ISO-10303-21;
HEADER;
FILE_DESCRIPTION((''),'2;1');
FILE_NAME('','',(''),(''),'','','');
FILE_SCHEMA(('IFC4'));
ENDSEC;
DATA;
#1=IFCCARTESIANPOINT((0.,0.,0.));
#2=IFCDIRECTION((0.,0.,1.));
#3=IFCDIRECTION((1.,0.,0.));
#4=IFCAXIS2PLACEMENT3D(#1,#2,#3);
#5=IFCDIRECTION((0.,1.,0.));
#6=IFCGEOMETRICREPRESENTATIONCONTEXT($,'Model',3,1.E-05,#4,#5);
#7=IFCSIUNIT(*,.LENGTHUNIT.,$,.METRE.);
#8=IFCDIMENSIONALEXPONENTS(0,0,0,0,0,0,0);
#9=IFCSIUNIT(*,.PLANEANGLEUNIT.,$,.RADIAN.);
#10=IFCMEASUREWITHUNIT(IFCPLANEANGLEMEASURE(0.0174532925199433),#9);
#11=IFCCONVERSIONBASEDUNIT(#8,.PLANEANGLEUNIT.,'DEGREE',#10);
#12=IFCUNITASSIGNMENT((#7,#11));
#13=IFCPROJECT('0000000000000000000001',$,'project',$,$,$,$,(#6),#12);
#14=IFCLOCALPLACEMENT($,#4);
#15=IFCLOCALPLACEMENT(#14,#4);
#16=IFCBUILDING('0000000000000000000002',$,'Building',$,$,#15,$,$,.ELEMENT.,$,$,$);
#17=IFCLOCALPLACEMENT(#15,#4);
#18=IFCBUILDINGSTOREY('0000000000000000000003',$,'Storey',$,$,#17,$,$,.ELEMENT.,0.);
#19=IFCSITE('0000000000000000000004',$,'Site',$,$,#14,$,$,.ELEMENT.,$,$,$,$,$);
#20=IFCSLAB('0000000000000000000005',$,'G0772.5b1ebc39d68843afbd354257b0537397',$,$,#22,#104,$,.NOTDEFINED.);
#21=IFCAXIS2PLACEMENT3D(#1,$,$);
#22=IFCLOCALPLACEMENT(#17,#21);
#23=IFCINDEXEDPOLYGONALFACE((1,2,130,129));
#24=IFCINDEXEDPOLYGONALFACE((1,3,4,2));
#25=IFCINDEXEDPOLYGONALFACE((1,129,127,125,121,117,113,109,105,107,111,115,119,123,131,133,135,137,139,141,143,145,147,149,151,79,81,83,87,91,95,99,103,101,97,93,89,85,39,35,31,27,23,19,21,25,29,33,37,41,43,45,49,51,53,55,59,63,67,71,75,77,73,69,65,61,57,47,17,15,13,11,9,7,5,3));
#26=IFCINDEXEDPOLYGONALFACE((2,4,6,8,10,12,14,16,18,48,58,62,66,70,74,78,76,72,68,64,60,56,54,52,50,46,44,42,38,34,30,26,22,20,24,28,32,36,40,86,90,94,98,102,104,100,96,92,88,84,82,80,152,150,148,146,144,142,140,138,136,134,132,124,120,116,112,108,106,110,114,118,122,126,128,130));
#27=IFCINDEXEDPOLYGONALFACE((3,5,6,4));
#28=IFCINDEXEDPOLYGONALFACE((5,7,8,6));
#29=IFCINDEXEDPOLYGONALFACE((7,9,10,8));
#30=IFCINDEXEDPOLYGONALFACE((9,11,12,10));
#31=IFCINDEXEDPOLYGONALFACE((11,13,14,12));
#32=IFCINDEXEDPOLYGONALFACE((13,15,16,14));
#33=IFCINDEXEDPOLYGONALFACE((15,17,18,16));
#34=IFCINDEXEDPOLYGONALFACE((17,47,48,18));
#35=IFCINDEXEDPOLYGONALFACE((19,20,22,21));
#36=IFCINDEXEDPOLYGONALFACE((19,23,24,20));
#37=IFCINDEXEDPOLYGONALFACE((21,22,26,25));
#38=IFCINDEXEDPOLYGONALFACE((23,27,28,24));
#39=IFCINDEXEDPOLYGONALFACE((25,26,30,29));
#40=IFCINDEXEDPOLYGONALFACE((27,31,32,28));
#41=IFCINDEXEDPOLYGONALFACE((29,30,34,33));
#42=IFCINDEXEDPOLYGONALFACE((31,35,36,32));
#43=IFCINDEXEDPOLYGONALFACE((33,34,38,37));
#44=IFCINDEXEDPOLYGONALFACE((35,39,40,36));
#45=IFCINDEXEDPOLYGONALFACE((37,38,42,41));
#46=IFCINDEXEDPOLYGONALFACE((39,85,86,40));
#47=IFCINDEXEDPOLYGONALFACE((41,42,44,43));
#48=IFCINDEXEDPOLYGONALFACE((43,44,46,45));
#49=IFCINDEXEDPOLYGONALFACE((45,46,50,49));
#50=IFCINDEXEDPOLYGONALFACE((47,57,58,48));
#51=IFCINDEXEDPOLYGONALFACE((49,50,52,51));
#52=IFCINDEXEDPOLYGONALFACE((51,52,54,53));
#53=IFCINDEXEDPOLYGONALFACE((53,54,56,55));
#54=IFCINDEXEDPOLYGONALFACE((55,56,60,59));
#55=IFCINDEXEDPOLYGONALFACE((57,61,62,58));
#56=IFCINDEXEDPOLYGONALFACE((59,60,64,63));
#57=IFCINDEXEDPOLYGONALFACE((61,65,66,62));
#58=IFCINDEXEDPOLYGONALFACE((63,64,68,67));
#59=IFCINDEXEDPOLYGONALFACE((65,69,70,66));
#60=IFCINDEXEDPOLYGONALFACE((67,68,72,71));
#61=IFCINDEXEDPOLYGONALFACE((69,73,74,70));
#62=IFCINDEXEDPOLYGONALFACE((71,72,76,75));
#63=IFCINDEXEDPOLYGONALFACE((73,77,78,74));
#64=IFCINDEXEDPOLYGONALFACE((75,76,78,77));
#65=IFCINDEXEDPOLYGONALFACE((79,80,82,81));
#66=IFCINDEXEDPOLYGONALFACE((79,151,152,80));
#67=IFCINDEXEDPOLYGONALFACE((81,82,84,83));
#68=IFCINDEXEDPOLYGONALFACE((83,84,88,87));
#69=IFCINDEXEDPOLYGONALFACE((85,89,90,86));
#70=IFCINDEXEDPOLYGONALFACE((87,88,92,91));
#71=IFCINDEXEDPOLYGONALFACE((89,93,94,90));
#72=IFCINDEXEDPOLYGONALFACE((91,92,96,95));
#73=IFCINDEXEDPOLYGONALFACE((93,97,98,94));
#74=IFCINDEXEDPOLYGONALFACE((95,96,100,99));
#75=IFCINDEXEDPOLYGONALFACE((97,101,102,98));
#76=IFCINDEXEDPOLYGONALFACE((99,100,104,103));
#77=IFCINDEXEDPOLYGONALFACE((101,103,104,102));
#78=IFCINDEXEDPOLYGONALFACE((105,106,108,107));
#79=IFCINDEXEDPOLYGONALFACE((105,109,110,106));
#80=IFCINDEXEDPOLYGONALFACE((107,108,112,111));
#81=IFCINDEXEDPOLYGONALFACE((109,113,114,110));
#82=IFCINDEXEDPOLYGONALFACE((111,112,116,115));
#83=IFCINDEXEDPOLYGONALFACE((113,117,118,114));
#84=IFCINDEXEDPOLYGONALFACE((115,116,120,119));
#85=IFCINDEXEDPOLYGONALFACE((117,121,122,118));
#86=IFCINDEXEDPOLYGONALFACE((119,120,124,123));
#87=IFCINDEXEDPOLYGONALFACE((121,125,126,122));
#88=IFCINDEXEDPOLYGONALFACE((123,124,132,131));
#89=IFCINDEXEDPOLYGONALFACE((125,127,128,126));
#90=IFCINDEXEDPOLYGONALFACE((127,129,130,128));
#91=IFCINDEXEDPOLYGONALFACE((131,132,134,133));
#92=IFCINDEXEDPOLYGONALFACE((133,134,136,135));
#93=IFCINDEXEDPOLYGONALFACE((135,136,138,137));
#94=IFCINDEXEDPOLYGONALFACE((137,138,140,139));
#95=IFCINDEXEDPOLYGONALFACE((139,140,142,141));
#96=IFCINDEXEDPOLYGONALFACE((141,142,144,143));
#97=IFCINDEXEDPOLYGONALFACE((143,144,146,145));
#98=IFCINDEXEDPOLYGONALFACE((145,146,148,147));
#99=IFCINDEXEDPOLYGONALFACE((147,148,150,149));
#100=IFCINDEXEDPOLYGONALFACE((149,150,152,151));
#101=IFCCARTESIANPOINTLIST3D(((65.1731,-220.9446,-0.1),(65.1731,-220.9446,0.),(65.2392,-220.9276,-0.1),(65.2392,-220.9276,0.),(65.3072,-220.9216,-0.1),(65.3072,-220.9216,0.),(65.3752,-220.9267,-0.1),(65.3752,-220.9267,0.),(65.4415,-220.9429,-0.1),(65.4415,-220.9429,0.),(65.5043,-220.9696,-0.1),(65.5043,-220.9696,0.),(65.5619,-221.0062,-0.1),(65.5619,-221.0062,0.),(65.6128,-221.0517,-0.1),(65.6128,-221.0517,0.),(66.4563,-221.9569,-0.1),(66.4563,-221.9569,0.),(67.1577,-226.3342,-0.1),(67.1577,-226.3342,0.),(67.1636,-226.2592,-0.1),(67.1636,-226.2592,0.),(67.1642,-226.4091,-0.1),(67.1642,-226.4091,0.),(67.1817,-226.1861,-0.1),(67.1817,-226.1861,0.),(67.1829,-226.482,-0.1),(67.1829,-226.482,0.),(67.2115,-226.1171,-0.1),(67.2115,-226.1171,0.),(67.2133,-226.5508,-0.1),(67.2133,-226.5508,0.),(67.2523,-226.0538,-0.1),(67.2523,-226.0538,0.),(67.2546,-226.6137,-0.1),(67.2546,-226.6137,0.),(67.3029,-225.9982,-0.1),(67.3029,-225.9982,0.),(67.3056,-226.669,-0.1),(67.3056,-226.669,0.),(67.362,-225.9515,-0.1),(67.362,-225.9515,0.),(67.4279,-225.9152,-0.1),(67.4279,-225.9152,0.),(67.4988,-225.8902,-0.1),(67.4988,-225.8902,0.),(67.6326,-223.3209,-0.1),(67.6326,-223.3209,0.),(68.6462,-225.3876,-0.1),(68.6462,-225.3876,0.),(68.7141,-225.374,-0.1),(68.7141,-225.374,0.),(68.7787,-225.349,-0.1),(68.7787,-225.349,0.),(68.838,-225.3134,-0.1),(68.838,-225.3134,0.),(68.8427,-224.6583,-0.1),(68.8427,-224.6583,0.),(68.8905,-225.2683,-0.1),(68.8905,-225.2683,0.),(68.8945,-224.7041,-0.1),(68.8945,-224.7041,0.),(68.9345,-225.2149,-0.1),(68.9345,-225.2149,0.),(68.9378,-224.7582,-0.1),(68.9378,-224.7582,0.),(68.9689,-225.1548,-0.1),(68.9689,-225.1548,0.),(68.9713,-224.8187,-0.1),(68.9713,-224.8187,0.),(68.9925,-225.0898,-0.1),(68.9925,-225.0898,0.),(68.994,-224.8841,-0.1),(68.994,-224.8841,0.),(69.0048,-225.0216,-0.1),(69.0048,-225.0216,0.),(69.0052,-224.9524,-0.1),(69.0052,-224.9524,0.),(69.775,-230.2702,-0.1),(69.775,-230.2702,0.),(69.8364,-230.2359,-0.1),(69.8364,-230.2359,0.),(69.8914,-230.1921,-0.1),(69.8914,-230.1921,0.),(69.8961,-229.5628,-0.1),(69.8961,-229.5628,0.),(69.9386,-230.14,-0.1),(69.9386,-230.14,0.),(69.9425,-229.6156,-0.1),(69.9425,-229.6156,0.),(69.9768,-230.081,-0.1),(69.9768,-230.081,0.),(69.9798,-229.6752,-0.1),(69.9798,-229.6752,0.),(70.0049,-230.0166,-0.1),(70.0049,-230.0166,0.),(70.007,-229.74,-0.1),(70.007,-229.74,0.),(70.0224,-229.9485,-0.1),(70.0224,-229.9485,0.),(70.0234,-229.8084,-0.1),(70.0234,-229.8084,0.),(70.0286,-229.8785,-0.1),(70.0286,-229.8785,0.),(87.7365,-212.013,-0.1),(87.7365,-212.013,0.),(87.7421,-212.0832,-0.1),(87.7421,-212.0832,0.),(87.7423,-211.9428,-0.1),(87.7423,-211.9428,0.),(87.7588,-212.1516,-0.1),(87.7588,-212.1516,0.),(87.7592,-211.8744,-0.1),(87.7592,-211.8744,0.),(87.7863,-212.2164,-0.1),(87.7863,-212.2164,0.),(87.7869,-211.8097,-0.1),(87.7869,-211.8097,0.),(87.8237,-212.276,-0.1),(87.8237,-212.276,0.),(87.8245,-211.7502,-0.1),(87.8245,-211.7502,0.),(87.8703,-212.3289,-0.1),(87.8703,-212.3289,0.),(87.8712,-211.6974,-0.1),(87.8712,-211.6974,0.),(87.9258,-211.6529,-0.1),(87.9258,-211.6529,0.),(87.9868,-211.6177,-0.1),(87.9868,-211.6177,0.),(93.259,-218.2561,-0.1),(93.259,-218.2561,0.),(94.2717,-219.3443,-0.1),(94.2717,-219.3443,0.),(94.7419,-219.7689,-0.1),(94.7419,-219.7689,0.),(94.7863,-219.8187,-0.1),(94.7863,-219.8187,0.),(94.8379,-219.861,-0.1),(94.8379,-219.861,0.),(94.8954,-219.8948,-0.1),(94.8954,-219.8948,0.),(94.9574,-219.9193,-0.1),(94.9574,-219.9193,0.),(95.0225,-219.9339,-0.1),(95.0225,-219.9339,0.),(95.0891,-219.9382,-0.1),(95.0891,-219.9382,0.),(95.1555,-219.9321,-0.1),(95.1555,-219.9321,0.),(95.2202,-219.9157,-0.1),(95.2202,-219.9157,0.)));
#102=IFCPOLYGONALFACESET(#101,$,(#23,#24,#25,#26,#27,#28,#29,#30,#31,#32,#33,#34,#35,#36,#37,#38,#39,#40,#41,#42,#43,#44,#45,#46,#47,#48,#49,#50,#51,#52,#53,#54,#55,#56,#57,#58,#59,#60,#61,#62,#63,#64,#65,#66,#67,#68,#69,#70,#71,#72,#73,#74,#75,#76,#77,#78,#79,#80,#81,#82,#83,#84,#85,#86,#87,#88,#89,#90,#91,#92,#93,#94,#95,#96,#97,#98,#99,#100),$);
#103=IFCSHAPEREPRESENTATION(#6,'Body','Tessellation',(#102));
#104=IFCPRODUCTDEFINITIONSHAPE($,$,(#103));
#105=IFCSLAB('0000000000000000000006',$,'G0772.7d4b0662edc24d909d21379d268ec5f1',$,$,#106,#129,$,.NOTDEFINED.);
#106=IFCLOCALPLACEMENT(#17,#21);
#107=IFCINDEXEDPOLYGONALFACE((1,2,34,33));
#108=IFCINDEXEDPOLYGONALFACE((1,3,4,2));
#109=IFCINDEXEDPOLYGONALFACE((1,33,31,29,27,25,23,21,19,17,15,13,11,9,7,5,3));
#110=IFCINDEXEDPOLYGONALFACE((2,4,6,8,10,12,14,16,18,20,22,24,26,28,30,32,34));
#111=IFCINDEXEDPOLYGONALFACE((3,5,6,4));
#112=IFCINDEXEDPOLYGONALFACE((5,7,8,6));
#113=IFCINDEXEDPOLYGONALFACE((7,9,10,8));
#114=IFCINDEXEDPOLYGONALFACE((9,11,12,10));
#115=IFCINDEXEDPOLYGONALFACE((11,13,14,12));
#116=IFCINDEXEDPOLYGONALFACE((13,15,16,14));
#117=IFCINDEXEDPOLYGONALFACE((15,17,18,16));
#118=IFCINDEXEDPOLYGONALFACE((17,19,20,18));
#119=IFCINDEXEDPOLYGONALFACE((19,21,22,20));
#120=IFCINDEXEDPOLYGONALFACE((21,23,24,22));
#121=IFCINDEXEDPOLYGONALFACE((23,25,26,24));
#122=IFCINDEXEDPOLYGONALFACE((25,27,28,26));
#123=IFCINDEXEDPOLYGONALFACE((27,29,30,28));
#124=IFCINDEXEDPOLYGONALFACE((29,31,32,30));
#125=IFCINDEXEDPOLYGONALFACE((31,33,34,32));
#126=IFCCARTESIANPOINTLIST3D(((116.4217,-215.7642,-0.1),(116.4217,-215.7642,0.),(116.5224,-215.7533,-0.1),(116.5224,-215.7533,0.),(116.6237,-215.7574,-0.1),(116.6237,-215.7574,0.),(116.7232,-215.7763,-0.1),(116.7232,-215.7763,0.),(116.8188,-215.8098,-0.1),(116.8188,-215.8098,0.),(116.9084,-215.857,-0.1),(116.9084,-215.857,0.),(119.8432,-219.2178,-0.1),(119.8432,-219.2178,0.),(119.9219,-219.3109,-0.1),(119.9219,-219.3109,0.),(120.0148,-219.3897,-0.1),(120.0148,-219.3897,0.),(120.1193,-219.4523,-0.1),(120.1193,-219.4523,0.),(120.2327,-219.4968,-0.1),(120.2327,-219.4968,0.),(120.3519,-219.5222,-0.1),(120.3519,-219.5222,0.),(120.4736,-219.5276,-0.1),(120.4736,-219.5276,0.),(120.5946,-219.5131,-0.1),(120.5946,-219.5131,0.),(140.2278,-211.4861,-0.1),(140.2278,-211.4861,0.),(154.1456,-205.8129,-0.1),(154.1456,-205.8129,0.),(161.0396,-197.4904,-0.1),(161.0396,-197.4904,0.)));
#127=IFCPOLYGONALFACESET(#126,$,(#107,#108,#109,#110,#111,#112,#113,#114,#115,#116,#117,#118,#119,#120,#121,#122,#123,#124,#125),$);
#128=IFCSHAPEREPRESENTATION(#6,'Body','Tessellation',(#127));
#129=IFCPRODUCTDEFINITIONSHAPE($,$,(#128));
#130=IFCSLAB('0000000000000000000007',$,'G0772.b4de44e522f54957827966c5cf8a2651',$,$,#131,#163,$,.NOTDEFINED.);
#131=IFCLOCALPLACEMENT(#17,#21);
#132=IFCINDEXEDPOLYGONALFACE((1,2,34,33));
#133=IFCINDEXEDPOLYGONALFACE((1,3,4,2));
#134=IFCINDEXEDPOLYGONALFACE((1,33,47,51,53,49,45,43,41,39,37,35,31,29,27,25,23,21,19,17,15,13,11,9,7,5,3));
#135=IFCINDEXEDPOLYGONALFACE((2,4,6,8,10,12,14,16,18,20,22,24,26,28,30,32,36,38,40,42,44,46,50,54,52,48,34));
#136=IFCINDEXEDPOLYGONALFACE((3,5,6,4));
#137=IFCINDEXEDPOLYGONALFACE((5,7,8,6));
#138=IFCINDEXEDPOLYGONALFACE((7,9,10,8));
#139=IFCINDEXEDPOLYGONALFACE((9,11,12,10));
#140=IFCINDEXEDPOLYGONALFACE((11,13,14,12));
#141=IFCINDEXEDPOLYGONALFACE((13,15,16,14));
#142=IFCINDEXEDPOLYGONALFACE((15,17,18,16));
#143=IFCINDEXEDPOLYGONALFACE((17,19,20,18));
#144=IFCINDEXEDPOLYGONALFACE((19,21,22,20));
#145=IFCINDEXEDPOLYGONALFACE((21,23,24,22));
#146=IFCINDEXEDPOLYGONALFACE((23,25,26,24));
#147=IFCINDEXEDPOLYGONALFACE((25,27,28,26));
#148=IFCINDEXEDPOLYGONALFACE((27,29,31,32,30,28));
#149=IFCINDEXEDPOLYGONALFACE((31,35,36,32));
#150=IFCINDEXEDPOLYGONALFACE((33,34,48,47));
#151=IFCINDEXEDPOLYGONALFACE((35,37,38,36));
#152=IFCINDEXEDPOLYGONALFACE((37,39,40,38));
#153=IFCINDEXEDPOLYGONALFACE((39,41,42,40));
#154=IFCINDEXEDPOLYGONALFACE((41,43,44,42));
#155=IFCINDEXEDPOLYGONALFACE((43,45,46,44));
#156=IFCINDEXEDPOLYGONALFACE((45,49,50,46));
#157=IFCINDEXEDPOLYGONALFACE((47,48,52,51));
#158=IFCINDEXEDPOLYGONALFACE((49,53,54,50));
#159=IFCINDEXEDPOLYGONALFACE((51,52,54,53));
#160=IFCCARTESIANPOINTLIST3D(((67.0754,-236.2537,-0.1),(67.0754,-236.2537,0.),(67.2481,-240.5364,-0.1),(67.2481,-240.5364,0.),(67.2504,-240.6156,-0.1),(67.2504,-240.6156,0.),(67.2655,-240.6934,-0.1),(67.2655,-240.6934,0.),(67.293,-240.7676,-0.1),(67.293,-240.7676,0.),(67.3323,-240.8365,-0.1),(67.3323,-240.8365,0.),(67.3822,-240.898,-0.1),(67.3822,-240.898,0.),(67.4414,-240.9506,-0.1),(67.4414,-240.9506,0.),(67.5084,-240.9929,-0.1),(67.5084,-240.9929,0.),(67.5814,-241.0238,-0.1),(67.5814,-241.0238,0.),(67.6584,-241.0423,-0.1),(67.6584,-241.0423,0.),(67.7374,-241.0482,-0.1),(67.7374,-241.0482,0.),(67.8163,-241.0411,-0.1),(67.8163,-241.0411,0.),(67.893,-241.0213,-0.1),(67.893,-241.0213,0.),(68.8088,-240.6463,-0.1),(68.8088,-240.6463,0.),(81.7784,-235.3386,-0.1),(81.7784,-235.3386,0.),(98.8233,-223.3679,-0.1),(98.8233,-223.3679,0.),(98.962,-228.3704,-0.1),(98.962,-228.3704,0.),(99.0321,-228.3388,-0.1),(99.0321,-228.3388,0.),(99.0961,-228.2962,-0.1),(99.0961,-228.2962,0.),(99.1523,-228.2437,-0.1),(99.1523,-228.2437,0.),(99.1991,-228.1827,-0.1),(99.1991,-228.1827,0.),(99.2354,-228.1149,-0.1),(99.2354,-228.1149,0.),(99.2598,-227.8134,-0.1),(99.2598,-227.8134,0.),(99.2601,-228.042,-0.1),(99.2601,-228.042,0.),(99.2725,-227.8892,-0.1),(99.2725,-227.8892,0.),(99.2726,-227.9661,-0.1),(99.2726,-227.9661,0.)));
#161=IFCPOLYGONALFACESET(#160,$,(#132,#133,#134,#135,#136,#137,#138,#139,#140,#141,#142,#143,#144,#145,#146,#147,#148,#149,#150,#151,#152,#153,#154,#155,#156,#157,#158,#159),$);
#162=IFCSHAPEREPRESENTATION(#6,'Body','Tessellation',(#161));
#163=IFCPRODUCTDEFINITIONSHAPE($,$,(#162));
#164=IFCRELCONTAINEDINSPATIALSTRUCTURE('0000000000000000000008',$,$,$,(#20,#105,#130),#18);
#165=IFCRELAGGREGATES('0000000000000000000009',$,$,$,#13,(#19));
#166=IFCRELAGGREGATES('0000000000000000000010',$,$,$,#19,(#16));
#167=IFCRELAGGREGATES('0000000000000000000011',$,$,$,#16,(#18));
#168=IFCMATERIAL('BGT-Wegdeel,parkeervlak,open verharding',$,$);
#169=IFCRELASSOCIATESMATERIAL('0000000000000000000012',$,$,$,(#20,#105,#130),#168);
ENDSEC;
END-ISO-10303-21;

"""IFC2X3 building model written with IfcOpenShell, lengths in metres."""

from ifc_helpers import new_model, entity, si_unit, converted_unit, direction, frame, origin_with_axes, place, context, project, spatial, polyline, outline, extrude, material, element, save


model = new_model("IFC2X3")

# Units and contexts
model_context = context("Model", 3, precision=1e-05, world=origin_with_axes(), true_north=direction((0.0, 1.0, 0.0)))
ifc_project = project(units=[si_unit("LENGTHUNIT", "METRE"), converted_unit("PLANEANGLEUNIT", "DEGREE", entity("IfcPlaneAngleMeasure", 0.0174532925199433), si_unit("PLANEANGLEUNIT", "RADIAN"), dimensions=[0, 0, 0, 0, 0, 0, 0])], contexts=[model_context])

# Site, building, storey
site_placement = place(None, origin_with_axes())
site = spatial("IfcSite", under=ifc_project, at=site_placement, Name="Site", CompositionType="ELEMENT")
building_placement = place(site_placement, origin_with_axes())
building = spatial("IfcBuilding", under=site, at=building_placement, Name="Building", CompositionType="ELEMENT")
storey_placement = place(building_placement, origin_with_axes())
storey = spatial("IfcBuildingStorey", under=building, at=storey_placement, Name="Storey", CompositionType="ELEMENT", Elevation=0.0)

# Slabs
ifc_material_1 = material(Name="BGT-Wegdeel,parkeervlak,open verharding")
slab_1_placement = place(storey_placement, frame((0.0, 0.0, -0.1), z_axis=(0.0, 0.0, 1.0), x_axis=(1.0, 0.0, 0.0)))
element("IfcSlab", 1, at=slab_1_placement, inside=storey, material=ifc_material_1, Name="G0772.5b1ebc39d68843afbd354257b0537397", PredefinedType="NOTDEFINED", context=model_context, shape_type="SweptSolid", body=[
    extrude(outline(polyline([(87.9868, -211.6177), (87.9258, -211.6529), (87.8712, -211.6974), (87.8245, -211.7502), (87.7869, -211.8097), (87.7592, -211.8744), (87.7423, -211.9428), (87.7365, -212.013), (87.7421, -212.0832), (87.7588, -212.1516), (87.7863, -212.2164), (87.8237, -212.276), (87.8703, -212.3289), (93.259, -218.2561), (94.2717, -219.3443), (94.7419, -219.7689), (94.7863, -219.8187), (94.8379, -219.861), (94.8954, -219.8948), (94.9574, -219.9193), (95.0225, -219.9339), (95.0891, -219.9382), (95.1555, -219.9321), (95.2202, -219.9157), (69.775, -230.2702), (69.8364, -230.2359), (69.8914, -230.1921), (69.9386, -230.14), (69.9768, -230.081), (70.0049, -230.0166), (70.0224, -229.9485), (70.0286, -229.8785), (70.0234, -229.8084), (70.007, -229.74), (69.9798, -229.6752), (69.9425, -229.6156), (69.8961, -229.5628), (67.3056, -226.669), (67.2546, -226.6137), (67.2133, -226.5508), (67.1829, -226.482), (67.1642, -226.4091), (67.1577, -226.3342), (67.1636, -226.2592), (67.1817, -226.1861), (67.2115, -226.1171), (67.2523, -226.0538), (67.3029, -225.9982), (67.362, -225.9515), (67.4279, -225.9152), (67.4988, -225.8902), (68.6462, -225.3876), (68.7141, -225.374), (68.7787, -225.349), (68.838, -225.3134), (68.8905, -225.2683), (68.9345, -225.2149), (68.9689, -225.1548), (68.9925, -225.0898), (69.0048, -225.0216), (69.0052, -224.9524), (68.994, -224.8841), (68.9713, -224.8187), (68.9378, -224.7582), (68.8945, -224.7041), (68.8427, -224.6583), (67.6326, -223.3209), (66.4563, -221.9569), (65.6128, -221.0517), (65.5619, -221.0062), (65.5043, -220.9696), (65.4415, -220.9429), (65.3752, -220.9267), (65.3072, -220.9216), (65.2392, -220.9276), (65.1731, -220.9446), (87.9868, -211.6177)])), origin_with_axes(), (0.0, 0.0, 1.0), 0.1),
])
slab_2_placement = place(storey_placement, frame((0.0, 0.0, -0.1), z_axis=(0.0, 0.0, 1.0), x_axis=(1.0, 0.0, 0.0)))
element("IfcSlab", 2, at=slab_2_placement, inside=storey, material=ifc_material_1, Name="G0772.7d4b0662edc24d909d21379d268ec5f1", PredefinedType="NOTDEFINED", context=model_context, shape_type="SweptSolid", body=[
    extrude(outline(polyline([(140.2278, -211.4861), (120.5946, -219.5131), (120.4736, -219.5276), (120.3519, -219.5222), (120.2327, -219.4968), (120.1193, -219.4523), (120.0148, -219.3897), (119.9219, -219.3109), (119.8432, -219.2178), (116.9084, -215.857), (116.8188, -215.8098), (116.7232, -215.7763), (116.6237, -215.7574), (116.5224, -215.7533), (116.4217, -215.7642), (161.0396, -197.4904), (154.1456, -205.8129), (140.2278, -211.4861)])), origin_with_axes(), (0.0, 0.0, 1.0), 0.1),
])
slab_3_placement = place(storey_placement, frame((0.0, 0.0, -0.1), z_axis=(0.0, 0.0, 1.0), x_axis=(1.0, 0.0, 0.0)))
element("IfcSlab", 3, at=slab_3_placement, inside=storey, material=ifc_material_1, Name="G0772.b4de44e522f54957827966c5cf8a2651", PredefinedType="NOTDEFINED", context=model_context, shape_type="SweptSolid", body=[
    extrude(outline(polyline([(98.8233, -223.3679), (99.2598, -227.8134), (99.2725, -227.8892), (99.2726, -227.9661), (99.2601, -228.042), (99.2354, -228.1149), (99.1991, -228.1827), (99.1523, -228.2437), (99.0961, -228.2962), (99.0321, -228.3388), (98.962, -228.3704), (81.7784, -235.3386), (68.8088, -240.6463), (67.893, -241.0213), (67.8163, -241.0411), (67.7374, -241.0482), (67.6584, -241.0423), (67.5814, -241.0238), (67.5084, -240.9929), (67.4414, -240.9506), (67.3822, -240.898), (67.3323, -240.8365), (67.293, -240.7676), (67.2655, -240.6934), (67.2504, -240.6156), (67.2481, -240.5364), (67.0754, -236.2537), (98.8233, -223.3679)])), origin_with_axes(), (0.0, 0.0, 1.0), 0.1),
])

save(model, "model.ifc")
